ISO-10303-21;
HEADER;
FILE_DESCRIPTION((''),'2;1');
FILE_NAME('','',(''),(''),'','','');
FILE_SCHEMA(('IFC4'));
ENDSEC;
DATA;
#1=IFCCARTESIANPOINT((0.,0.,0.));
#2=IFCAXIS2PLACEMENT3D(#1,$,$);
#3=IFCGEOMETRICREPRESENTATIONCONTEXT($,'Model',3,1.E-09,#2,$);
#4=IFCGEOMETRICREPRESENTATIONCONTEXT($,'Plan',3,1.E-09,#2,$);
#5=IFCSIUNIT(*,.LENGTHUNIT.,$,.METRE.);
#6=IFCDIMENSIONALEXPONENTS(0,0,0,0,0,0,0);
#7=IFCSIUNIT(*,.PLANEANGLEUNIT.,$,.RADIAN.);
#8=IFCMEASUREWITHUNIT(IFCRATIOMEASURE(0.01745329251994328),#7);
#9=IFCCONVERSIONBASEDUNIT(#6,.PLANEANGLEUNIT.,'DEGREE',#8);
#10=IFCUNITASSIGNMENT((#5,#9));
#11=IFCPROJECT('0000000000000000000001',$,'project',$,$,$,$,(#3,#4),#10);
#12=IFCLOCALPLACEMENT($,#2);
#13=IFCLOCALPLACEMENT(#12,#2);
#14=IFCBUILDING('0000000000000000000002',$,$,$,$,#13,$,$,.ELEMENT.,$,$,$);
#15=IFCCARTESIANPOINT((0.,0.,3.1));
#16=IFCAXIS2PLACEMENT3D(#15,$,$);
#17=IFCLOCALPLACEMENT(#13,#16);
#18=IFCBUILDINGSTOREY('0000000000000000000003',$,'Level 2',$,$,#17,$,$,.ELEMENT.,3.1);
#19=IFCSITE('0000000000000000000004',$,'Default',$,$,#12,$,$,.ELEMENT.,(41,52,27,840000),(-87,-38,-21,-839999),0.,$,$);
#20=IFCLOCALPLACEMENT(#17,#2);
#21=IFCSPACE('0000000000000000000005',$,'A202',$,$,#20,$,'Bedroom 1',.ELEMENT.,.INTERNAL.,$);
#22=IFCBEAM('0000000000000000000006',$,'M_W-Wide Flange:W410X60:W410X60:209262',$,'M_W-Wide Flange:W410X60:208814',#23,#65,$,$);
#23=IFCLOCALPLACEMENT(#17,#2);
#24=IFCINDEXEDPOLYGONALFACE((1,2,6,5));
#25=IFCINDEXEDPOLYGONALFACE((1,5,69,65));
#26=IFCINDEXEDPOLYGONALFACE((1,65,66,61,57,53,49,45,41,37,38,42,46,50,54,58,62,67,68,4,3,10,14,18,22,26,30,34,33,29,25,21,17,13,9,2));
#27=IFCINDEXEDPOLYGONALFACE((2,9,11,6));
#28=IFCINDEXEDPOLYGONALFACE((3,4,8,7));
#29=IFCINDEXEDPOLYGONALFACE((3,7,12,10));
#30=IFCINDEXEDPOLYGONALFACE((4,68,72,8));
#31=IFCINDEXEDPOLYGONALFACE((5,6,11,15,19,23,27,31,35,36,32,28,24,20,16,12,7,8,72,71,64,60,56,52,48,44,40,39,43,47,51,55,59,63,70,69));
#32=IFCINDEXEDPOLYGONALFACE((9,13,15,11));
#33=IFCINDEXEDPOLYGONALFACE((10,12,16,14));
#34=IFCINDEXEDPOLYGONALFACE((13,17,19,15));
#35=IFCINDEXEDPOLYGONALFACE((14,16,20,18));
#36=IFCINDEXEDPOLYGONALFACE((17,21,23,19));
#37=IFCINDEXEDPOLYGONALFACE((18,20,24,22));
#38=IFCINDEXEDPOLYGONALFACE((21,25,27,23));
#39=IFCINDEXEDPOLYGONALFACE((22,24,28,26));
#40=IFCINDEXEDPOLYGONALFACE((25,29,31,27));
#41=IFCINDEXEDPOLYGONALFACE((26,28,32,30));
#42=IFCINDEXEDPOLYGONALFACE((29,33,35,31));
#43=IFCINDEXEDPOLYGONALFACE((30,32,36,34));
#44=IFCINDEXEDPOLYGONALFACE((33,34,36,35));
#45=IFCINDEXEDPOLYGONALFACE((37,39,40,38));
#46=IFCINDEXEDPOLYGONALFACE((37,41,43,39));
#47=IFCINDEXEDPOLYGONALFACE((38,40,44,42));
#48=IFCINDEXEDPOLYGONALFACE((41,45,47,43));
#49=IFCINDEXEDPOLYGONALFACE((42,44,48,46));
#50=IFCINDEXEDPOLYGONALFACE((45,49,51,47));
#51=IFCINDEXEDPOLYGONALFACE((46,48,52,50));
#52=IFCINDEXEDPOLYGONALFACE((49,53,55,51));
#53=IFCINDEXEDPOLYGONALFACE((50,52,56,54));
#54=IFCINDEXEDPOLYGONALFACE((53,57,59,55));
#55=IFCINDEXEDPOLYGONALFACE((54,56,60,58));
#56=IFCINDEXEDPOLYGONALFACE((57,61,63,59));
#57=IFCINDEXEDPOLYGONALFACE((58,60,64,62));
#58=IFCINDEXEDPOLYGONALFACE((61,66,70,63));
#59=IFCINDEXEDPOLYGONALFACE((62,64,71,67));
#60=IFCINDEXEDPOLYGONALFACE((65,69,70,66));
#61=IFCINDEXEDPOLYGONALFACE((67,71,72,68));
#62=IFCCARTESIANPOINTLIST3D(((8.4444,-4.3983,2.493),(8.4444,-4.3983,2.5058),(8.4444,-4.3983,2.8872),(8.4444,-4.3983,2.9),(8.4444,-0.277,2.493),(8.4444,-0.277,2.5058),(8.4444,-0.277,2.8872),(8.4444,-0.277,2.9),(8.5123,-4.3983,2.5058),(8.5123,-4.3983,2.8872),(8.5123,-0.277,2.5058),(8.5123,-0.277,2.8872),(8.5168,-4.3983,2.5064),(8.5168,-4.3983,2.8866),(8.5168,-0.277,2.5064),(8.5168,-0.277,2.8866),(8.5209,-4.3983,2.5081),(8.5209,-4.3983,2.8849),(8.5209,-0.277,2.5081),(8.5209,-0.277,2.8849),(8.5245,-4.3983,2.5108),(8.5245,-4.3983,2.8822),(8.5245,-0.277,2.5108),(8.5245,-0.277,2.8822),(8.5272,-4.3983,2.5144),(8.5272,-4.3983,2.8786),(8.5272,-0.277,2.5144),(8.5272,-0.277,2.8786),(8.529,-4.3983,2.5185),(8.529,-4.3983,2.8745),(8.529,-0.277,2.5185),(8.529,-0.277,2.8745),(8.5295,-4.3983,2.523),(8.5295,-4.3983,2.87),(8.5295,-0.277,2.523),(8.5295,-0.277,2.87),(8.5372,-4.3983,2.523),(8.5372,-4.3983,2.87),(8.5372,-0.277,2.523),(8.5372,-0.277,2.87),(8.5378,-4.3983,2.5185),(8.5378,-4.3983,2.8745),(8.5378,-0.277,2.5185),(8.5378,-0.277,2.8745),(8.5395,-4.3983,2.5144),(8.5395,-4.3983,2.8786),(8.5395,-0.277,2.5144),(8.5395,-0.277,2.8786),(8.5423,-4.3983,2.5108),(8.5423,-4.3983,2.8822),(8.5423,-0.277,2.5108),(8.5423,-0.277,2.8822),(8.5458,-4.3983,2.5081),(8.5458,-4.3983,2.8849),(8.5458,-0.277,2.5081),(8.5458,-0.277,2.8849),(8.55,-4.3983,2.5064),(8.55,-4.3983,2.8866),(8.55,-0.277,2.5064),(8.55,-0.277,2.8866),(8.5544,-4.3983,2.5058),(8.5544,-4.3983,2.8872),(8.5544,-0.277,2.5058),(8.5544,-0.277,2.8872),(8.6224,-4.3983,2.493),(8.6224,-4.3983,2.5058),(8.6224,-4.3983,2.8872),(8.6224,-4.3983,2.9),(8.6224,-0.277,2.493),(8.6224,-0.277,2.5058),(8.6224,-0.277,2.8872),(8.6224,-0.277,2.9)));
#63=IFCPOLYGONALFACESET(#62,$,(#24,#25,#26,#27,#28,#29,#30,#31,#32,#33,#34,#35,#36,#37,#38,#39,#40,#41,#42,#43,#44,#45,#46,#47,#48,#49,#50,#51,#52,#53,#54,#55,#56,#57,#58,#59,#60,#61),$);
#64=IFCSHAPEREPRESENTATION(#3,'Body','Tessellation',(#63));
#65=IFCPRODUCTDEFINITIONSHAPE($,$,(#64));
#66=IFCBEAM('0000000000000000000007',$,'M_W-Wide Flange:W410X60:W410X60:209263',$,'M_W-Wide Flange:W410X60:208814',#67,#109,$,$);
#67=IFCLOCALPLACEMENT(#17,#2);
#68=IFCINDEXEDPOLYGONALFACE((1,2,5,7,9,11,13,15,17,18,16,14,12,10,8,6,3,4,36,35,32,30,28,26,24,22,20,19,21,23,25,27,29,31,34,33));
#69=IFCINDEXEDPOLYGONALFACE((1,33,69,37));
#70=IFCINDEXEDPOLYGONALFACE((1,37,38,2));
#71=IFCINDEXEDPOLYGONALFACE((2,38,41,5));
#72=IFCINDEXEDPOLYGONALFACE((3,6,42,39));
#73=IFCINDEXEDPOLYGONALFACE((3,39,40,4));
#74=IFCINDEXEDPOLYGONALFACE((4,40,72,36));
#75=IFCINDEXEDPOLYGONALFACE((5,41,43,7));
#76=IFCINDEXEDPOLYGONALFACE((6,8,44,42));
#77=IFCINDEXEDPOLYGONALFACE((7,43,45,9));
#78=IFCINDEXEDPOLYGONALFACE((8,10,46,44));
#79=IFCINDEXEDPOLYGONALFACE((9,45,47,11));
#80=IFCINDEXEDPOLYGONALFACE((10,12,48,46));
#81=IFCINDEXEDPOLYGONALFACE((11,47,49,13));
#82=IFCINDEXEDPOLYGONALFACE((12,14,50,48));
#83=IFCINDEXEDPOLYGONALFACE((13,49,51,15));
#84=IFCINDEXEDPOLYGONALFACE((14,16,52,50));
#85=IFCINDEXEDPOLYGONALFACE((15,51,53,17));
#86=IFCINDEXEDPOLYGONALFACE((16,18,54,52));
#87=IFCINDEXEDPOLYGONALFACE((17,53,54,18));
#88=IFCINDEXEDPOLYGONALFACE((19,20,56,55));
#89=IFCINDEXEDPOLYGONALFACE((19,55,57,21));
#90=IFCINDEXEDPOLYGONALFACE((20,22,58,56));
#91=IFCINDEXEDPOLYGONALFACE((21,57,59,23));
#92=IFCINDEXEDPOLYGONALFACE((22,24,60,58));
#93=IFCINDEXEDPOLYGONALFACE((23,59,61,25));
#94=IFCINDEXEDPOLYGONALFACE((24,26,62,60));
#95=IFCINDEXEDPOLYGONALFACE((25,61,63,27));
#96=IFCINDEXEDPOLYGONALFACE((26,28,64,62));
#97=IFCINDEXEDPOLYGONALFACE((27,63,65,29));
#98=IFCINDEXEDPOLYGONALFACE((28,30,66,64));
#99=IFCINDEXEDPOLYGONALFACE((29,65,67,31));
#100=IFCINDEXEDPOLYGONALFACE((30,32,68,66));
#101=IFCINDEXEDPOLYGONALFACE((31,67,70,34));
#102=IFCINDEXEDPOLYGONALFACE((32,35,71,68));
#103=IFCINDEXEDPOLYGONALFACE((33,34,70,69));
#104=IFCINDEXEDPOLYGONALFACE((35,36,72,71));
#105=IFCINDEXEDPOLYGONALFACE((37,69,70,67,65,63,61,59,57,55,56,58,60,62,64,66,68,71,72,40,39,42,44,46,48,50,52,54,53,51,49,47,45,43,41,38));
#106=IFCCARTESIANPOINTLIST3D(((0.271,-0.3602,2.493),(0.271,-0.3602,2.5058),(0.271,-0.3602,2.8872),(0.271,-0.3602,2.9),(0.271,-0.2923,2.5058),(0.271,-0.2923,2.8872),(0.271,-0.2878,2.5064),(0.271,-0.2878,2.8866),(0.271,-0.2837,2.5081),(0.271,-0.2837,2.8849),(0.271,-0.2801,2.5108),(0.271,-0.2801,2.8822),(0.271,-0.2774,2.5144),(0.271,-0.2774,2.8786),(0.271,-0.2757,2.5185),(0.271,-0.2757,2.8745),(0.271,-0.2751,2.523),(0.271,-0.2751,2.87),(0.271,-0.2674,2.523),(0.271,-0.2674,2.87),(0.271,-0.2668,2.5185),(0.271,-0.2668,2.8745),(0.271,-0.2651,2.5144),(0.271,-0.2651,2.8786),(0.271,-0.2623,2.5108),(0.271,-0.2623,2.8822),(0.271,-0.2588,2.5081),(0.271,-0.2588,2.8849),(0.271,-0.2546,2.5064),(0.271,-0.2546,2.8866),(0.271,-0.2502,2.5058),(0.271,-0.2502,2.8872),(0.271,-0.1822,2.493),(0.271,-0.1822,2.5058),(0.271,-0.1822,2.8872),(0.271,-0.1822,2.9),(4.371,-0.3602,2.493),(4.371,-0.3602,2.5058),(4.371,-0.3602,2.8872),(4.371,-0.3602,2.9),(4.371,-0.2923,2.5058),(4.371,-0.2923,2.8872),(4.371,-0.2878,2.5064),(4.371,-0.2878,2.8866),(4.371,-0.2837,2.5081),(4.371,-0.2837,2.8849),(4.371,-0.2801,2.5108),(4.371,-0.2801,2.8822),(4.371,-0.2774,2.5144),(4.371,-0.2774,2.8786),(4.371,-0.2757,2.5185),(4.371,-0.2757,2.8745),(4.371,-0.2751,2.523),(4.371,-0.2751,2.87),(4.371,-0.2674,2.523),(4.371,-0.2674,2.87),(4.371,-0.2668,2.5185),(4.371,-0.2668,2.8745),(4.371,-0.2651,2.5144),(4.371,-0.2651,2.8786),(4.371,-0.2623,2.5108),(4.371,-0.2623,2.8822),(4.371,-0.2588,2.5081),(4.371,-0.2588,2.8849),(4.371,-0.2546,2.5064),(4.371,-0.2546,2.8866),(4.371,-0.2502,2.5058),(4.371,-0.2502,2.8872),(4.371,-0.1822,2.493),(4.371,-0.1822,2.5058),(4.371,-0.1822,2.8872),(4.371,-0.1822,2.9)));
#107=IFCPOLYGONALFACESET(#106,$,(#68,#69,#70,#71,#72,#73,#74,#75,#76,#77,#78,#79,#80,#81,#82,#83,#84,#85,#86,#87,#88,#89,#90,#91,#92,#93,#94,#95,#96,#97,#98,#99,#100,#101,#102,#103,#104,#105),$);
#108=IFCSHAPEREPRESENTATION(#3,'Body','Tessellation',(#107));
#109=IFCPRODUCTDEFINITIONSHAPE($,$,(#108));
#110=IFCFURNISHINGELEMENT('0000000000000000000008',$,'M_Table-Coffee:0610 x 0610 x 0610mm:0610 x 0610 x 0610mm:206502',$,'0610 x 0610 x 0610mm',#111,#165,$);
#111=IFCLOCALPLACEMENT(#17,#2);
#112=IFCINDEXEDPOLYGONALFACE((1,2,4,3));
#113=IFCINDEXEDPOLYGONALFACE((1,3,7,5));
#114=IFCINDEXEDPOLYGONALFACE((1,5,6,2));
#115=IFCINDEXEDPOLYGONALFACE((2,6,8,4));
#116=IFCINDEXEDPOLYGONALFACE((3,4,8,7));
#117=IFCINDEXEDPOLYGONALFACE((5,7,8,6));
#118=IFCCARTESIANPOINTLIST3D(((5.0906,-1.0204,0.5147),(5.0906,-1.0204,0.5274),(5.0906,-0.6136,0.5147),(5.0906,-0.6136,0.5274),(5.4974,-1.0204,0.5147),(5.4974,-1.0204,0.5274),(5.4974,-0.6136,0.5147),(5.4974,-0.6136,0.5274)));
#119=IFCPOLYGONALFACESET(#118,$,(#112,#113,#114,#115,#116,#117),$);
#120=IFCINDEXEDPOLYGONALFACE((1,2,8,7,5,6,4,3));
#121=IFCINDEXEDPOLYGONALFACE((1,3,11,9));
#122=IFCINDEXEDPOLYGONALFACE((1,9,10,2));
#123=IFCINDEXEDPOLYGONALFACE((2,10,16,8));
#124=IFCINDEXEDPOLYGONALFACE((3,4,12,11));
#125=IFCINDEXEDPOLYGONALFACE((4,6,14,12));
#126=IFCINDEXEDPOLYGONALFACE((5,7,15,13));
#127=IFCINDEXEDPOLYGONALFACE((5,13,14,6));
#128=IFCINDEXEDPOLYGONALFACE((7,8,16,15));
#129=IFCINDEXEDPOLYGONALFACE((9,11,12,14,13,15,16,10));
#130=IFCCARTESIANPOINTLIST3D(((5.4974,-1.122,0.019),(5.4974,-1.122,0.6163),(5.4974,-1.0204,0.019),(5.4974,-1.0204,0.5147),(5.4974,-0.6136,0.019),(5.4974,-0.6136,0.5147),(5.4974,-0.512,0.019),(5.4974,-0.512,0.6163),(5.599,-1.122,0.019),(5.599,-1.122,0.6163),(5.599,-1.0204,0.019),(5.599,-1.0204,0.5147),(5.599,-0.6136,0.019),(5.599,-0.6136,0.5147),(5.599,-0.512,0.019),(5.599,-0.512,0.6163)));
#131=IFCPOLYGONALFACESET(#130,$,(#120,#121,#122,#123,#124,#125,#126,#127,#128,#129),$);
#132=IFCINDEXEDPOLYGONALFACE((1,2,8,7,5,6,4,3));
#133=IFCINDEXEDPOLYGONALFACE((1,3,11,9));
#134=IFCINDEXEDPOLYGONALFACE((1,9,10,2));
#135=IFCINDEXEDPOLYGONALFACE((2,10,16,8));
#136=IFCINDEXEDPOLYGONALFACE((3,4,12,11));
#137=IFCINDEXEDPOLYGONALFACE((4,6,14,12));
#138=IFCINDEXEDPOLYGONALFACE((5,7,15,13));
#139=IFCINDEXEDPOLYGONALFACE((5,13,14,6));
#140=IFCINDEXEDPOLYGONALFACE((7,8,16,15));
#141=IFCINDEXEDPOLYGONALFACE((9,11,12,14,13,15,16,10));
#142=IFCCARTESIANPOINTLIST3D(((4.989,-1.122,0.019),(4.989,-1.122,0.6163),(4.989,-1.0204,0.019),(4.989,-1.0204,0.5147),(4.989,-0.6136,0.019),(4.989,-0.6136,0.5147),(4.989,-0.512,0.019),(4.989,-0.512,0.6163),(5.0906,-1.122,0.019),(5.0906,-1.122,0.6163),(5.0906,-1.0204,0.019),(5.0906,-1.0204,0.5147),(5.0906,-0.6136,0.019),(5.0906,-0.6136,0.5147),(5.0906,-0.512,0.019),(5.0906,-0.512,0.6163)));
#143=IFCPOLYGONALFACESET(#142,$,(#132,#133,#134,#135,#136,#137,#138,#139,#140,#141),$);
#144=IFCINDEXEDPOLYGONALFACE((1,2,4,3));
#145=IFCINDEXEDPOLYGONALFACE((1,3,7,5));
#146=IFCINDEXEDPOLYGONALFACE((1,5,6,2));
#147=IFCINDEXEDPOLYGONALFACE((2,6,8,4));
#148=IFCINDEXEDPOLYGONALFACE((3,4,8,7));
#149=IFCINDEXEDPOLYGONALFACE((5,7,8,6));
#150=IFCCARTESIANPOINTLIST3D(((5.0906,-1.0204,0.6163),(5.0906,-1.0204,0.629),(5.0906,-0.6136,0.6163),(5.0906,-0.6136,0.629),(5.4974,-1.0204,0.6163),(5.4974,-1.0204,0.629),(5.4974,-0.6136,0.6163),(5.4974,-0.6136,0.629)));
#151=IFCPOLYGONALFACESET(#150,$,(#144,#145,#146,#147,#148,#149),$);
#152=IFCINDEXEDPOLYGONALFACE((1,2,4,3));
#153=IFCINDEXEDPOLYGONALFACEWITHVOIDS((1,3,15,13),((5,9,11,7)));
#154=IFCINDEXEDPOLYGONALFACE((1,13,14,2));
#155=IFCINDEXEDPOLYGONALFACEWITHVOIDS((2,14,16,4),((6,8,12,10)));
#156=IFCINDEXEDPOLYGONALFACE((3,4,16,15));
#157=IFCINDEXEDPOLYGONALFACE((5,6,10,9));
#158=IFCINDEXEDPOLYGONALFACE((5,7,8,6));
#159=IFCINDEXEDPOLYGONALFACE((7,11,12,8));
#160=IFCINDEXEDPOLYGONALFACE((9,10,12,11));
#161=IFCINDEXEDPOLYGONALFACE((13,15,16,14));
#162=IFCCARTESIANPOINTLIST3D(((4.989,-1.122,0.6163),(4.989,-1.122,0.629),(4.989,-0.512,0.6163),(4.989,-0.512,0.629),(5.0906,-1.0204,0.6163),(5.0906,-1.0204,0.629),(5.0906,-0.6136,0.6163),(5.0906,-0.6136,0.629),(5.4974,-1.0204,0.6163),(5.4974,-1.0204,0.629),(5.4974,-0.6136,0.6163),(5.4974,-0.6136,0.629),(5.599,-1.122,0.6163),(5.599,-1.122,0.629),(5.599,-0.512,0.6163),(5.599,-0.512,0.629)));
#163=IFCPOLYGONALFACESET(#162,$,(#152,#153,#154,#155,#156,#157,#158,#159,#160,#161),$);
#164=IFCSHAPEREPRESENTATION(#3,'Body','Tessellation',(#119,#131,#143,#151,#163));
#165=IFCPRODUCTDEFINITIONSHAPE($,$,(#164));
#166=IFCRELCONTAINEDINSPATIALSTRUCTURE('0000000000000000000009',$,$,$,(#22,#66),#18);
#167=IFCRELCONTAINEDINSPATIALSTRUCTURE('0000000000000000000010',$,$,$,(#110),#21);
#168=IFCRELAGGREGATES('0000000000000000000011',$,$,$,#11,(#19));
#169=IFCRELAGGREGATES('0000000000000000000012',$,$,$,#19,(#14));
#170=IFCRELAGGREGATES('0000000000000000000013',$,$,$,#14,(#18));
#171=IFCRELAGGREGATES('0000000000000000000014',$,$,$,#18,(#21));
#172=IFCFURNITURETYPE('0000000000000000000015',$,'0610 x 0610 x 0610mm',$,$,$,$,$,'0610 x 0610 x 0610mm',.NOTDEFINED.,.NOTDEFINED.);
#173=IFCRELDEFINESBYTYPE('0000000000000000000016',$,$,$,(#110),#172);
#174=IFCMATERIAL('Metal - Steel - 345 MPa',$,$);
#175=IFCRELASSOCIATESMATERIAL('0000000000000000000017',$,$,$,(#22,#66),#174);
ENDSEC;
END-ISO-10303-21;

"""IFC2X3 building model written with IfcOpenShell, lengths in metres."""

from ifc_helpers import new_model, entity, si_unit, converted_unit, frame, frame_2d, origin, origin_2d_with_axis, place, context, project, spatial, polyline, circle_curve, parameter, trimmed, segment, composite_curve, rectangle, outline, extrude, source, transform, mapped, material, type_object, type_shapes, element, save


model = new_model("IFC2X3")

# Units and contexts
model_context = context("Model", 3, precision=1e-09, world=origin())
plan_context = context("Plan", 3, precision=1e-09, world=origin())
ifc_project = project(units=[si_unit("LENGTHUNIT", "METRE"), converted_unit("PLANEANGLEUNIT", "DEGREE", entity("IfcRatioMeasure", 0.01745329251994328), si_unit("PLANEANGLEUNIT", "RADIAN"), dimensions=[0, 0, 0, 0, 0, 0, 0])], contexts=[model_context, plan_context])

# Site, building, storey
site_placement = place(None, origin())
site = spatial("IfcSite", under=ifc_project, at=site_placement, Name="Default", CompositionType="ELEMENT", RefLatitude=(41, 52, 27, 840000), RefLongitude=(-87, -38, -21, -839999), RefElevation=0.0)
building_placement = place(site_placement, origin())
building = spatial("IfcBuilding", under=site, at=building_placement, CompositionType="ELEMENT")
storey_placement = place(building_placement, frame((0.0, 0.0, 3.1)))
storey = spatial("IfcBuildingStorey", under=building, at=storey_placement, Name="Level 2", CompositionType="ELEMENT", Elevation=3.1)

# Beams
ifc_material_1 = material(Name="Metal - Steel - 345 MPa")
beam_1_placement = place(storey_placement, frame((8.5334, -4.3983, 2.9)))
element("IfcBeam", 1, at=beam_1_placement, inside=storey, material=ifc_material_1, Name="M_W-Wide Flange:W410X60:W410X60:209262", ObjectType="M_W-Wide Flange:W410X60:208814", context=model_context, shape_type="SweptSolid", body=[
    extrude(outline(composite_curve([segment(polyline([(-0.089, -0.1907), (-0.089, -0.2035)]), True, "CONTINUOUS"), segment(polyline([(-0.089, -0.2035), (0.089, -0.2035)]), True, "CONTINUOUS"), segment(polyline([(0.089, -0.2035), (0.089, -0.1907)]), True, "CONTINUOUS"), segment(polyline([(0.089, -0.1907), (0.021, -0.1907)]), True, "CONTINUOUS"), segment(trimmed(circle_curve(frame_2d((0.021, -0.1735), x_axis=(0.0, -1.0)), 0.0172), [parameter(270.0)], [parameter(360.0)], True, "PARAMETER"), False, "CONTINUOUS"), segment(polyline([(0.0038, -0.1735), (0.0038, 0.1735)]), True, "CONTINUOUS"), segment(trimmed(circle_curve(frame_2d((0.021, 0.1735), x_axis=(-1.0, 0.0)), 0.0172), [parameter(270.0)], [parameter(360.0)], True, "PARAMETER"), False, "CONTINUOUS"), segment(polyline([(0.021, 0.1907), (0.089, 0.1907)]), True, "CONTINUOUS"), segment(polyline([(0.089, 0.1907), (0.089, 0.2035)]), True, "CONTINUOUS"), segment(polyline([(0.089, 0.2035), (-0.089, 0.2035)]), True, "CONTINUOUS"), segment(polyline([(-0.089, 0.2035), (-0.089, 0.1907)]), True, "CONTINUOUS"), segment(polyline([(-0.089, 0.1907), (-0.0211, 0.1907)]), True, "CONTINUOUS"), segment(trimmed(circle_curve(frame_2d((-0.0211, 0.1735), x_axis=(0.0, 1.0)), 0.0172), [parameter(270.0)], [parameter(0.0)], True, "PARAMETER"), False, "CONTINUOUS"), segment(polyline([(-0.0039, 0.1735), (-0.0039, -0.1735)]), True, "CONTINUOUS"), segment(trimmed(circle_curve(frame_2d((-0.0211, -0.1735), x_axis=(1.0, 0.0)), 0.0172), [parameter(270.0)], [parameter(0.0)], True, "PARAMETER"), False, "CONTINUOUS"), segment(polyline([(-0.0211, -0.1907), (-0.089, -0.1907)]), True, "CONTINUOUS")], self_intersect=False)), frame((0.0, 0.0, -0.2035), z_axis=(0.0, -1.0, 0.0), x_axis=(1.0, 0.0, 0.0)), (0.0, 0.0, -1.0), 4.1213),
])
beam_2_placement = place(storey_placement, frame((4.371, -0.2712, 2.9), z_axis=(0.0, 0.0, 1.0), x_axis=(0.0, 1.0, 0.0)))
element("IfcBeam", 2, at=beam_2_placement, inside=storey, material=ifc_material_1, Name="M_W-Wide Flange:W410X60:W410X60:209263", ObjectType="M_W-Wide Flange:W410X60:208814", context=model_context, shape_type="SweptSolid", body=[
    extrude(outline(composite_curve([segment(polyline([(0.1907, -0.089), (0.2035, -0.089)]), True, "CONTINUOUS"), segment(polyline([(0.2035, -0.089), (0.2035, 0.089)]), True, "CONTINUOUS"), segment(polyline([(0.2035, 0.089), (0.1907, 0.089)]), True, "CONTINUOUS"), segment(polyline([(0.1907, 0.089), (0.1907, 0.0211)]), True, "CONTINUOUS"), segment(trimmed(circle_curve(frame_2d((0.1735, 0.0211), x_axis=(1.0, 0.0)), 0.0172), [parameter(270.0)], [parameter(360.0)], True, "PARAMETER"), False, "CONTINUOUS"), segment(polyline([(0.1735, 0.0039), (-0.1735, 0.0039)]), True, "CONTINUOUS"), segment(trimmed(circle_curve(frame_2d((-0.1735, 0.0211), x_axis=(0.0, -1.0)), 0.0172), [parameter(270.0)], [parameter(360.0)], True, "PARAMETER"), False, "CONTINUOUS"), segment(polyline([(-0.1907, 0.0211), (-0.1907, 0.089)]), True, "CONTINUOUS"), segment(polyline([(-0.1907, 0.089), (-0.2035, 0.089)]), True, "CONTINUOUS"), segment(polyline([(-0.2035, 0.089), (-0.2035, -0.089)]), True, "CONTINUOUS"), segment(polyline([(-0.2035, -0.089), (-0.1907, -0.089)]), True, "CONTINUOUS"), segment(polyline([(-0.1907, -0.089), (-0.1907, -0.0211)]), True, "CONTINUOUS"), segment(trimmed(circle_curve(frame_2d((-0.1735, -0.0211), x_axis=(-1.0, 0.0)), 0.0172), [parameter(270.0)], [parameter(0.0)], True, "PARAMETER"), False, "CONTINUOUS"), segment(polyline([(-0.1735, -0.0039), (0.1735, -0.0039)]), True, "CONTINUOUS"), segment(trimmed(circle_curve(frame_2d((0.1735, -0.0211), x_axis=(0.0, 1.0)), 0.0172), [parameter(270.0)], [parameter(0.0)], True, "PARAMETER"), False, "CONTINUOUS"), segment(polyline([(0.1907, -0.0211), (0.1907, -0.089)]), True, "CONTINUOUS")], self_intersect=False)), frame((0.0, 4.1, -0.2035), z_axis=(0.0, -1.0, 0.0), x_axis=(0.0, 0.0, -1.0)), (0.0, 0.0, 1.0), 4.1),
])

# Shared definitions
space_placement = place(storey_placement, origin())
space = spatial("IfcSpace", under=storey, at=space_placement, Name="A202", LongName="Bedroom 1", CompositionType="ELEMENT", InteriorOrExteriorSpace="INTERNAL")

# Furnishing element
furniture_type = type_object("IfcFurnitureType", Name="0610 x 0610 x 0610mm", ElementType="0610 x 0610 x 0610mm", AssemblyPlace="NOTDEFINED")
shared_shape_1 = source(origin(), model_context, "Body", "SweptSolid", [
    extrude(rectangle(XDim=0.4068, YDim=0.4068, at=origin_2d_with_axis()), frame((0.0183, 0.0952, 0.4957), z_axis=(0.0, 0.0, 1.0), x_axis=(-1.0, 0.0, 0.0)), (0.0, 0.0, 1.0), 0.0127),
    extrude(outline(polyline([(-0.2732, -0.305), (0.324, -0.305), (0.324, 0.305), (-0.2732, 0.305), (-0.2732, 0.2034), (0.2225, 0.2034), (0.2225, -0.2034), (-0.2732, -0.2034), (-0.2732, -0.305)])), frame((0.2217, 0.0952, 0.2732), z_axis=(1.0, 0.0, 0.0), x_axis=(0.0, 0.0, 1.0)), (0.0, 0.0, 1.0), 0.1016),
    extrude(outline(polyline([(-0.305, -0.3241), (0.305, -0.3241), (0.305, 0.2733), (0.2034, 0.2733), (0.2034, -0.2224), (-0.2034, -0.2224), (-0.2034, 0.2733), (-0.305, 0.2733), (-0.305, -0.3241)])), frame((-0.2867, 0.0952, 0.2733), z_axis=(1.0, 0.0, 0.0), x_axis=(0.0, -1.0, 0.0)), (0.0, 0.0, 1.0), 0.1016),
    extrude(rectangle(XDim=0.4068, YDim=0.4068, at=origin_2d_with_axis()), frame((0.0183, 0.0952, 0.5973), z_axis=(0.0, 0.0, 1.0), x_axis=(-1.0, 0.0, 0.0)), (0.0, 0.0, 1.0), 0.0127),
    extrude(outline(polyline([(-0.305, -0.305), (0.305, -0.305), (0.305, 0.305), (-0.305, 0.305), (-0.305, -0.305)]), holes=[polyline([(-0.2034, -0.2034), (-0.2034, 0.2034), (0.2034, 0.2034), (0.2034, -0.2034), (-0.2034, -0.2034)])]), frame((0.0183, 0.0952, 0.5973), z_axis=(0.0, 0.0, 1.0), x_axis=(-1.0, 0.0, 0.0)), (0.0, 0.0, 1.0), 0.0127),
])
type_shapes(furniture_type, [shared_shape_1])
furnishing_placement = place(space_placement, frame((5.2757, -0.9122, 0.019)))
element("IfcFurnishingElement", 3, at=furnishing_placement, inside=space, type_object=furniture_type, Name="M_Table-Coffee:0610 x 0610 x 0610mm:0610 x 0610 x 0610mm:206502", ObjectType="0610 x 0610 x 0610mm", context=model_context, shape_type="MappedRepresentation", body=[
    mapped(shared_shape_1, transform((0.0, 0.0, 0.0), scale=1.0)),
])

save(model, "model.ifc")
